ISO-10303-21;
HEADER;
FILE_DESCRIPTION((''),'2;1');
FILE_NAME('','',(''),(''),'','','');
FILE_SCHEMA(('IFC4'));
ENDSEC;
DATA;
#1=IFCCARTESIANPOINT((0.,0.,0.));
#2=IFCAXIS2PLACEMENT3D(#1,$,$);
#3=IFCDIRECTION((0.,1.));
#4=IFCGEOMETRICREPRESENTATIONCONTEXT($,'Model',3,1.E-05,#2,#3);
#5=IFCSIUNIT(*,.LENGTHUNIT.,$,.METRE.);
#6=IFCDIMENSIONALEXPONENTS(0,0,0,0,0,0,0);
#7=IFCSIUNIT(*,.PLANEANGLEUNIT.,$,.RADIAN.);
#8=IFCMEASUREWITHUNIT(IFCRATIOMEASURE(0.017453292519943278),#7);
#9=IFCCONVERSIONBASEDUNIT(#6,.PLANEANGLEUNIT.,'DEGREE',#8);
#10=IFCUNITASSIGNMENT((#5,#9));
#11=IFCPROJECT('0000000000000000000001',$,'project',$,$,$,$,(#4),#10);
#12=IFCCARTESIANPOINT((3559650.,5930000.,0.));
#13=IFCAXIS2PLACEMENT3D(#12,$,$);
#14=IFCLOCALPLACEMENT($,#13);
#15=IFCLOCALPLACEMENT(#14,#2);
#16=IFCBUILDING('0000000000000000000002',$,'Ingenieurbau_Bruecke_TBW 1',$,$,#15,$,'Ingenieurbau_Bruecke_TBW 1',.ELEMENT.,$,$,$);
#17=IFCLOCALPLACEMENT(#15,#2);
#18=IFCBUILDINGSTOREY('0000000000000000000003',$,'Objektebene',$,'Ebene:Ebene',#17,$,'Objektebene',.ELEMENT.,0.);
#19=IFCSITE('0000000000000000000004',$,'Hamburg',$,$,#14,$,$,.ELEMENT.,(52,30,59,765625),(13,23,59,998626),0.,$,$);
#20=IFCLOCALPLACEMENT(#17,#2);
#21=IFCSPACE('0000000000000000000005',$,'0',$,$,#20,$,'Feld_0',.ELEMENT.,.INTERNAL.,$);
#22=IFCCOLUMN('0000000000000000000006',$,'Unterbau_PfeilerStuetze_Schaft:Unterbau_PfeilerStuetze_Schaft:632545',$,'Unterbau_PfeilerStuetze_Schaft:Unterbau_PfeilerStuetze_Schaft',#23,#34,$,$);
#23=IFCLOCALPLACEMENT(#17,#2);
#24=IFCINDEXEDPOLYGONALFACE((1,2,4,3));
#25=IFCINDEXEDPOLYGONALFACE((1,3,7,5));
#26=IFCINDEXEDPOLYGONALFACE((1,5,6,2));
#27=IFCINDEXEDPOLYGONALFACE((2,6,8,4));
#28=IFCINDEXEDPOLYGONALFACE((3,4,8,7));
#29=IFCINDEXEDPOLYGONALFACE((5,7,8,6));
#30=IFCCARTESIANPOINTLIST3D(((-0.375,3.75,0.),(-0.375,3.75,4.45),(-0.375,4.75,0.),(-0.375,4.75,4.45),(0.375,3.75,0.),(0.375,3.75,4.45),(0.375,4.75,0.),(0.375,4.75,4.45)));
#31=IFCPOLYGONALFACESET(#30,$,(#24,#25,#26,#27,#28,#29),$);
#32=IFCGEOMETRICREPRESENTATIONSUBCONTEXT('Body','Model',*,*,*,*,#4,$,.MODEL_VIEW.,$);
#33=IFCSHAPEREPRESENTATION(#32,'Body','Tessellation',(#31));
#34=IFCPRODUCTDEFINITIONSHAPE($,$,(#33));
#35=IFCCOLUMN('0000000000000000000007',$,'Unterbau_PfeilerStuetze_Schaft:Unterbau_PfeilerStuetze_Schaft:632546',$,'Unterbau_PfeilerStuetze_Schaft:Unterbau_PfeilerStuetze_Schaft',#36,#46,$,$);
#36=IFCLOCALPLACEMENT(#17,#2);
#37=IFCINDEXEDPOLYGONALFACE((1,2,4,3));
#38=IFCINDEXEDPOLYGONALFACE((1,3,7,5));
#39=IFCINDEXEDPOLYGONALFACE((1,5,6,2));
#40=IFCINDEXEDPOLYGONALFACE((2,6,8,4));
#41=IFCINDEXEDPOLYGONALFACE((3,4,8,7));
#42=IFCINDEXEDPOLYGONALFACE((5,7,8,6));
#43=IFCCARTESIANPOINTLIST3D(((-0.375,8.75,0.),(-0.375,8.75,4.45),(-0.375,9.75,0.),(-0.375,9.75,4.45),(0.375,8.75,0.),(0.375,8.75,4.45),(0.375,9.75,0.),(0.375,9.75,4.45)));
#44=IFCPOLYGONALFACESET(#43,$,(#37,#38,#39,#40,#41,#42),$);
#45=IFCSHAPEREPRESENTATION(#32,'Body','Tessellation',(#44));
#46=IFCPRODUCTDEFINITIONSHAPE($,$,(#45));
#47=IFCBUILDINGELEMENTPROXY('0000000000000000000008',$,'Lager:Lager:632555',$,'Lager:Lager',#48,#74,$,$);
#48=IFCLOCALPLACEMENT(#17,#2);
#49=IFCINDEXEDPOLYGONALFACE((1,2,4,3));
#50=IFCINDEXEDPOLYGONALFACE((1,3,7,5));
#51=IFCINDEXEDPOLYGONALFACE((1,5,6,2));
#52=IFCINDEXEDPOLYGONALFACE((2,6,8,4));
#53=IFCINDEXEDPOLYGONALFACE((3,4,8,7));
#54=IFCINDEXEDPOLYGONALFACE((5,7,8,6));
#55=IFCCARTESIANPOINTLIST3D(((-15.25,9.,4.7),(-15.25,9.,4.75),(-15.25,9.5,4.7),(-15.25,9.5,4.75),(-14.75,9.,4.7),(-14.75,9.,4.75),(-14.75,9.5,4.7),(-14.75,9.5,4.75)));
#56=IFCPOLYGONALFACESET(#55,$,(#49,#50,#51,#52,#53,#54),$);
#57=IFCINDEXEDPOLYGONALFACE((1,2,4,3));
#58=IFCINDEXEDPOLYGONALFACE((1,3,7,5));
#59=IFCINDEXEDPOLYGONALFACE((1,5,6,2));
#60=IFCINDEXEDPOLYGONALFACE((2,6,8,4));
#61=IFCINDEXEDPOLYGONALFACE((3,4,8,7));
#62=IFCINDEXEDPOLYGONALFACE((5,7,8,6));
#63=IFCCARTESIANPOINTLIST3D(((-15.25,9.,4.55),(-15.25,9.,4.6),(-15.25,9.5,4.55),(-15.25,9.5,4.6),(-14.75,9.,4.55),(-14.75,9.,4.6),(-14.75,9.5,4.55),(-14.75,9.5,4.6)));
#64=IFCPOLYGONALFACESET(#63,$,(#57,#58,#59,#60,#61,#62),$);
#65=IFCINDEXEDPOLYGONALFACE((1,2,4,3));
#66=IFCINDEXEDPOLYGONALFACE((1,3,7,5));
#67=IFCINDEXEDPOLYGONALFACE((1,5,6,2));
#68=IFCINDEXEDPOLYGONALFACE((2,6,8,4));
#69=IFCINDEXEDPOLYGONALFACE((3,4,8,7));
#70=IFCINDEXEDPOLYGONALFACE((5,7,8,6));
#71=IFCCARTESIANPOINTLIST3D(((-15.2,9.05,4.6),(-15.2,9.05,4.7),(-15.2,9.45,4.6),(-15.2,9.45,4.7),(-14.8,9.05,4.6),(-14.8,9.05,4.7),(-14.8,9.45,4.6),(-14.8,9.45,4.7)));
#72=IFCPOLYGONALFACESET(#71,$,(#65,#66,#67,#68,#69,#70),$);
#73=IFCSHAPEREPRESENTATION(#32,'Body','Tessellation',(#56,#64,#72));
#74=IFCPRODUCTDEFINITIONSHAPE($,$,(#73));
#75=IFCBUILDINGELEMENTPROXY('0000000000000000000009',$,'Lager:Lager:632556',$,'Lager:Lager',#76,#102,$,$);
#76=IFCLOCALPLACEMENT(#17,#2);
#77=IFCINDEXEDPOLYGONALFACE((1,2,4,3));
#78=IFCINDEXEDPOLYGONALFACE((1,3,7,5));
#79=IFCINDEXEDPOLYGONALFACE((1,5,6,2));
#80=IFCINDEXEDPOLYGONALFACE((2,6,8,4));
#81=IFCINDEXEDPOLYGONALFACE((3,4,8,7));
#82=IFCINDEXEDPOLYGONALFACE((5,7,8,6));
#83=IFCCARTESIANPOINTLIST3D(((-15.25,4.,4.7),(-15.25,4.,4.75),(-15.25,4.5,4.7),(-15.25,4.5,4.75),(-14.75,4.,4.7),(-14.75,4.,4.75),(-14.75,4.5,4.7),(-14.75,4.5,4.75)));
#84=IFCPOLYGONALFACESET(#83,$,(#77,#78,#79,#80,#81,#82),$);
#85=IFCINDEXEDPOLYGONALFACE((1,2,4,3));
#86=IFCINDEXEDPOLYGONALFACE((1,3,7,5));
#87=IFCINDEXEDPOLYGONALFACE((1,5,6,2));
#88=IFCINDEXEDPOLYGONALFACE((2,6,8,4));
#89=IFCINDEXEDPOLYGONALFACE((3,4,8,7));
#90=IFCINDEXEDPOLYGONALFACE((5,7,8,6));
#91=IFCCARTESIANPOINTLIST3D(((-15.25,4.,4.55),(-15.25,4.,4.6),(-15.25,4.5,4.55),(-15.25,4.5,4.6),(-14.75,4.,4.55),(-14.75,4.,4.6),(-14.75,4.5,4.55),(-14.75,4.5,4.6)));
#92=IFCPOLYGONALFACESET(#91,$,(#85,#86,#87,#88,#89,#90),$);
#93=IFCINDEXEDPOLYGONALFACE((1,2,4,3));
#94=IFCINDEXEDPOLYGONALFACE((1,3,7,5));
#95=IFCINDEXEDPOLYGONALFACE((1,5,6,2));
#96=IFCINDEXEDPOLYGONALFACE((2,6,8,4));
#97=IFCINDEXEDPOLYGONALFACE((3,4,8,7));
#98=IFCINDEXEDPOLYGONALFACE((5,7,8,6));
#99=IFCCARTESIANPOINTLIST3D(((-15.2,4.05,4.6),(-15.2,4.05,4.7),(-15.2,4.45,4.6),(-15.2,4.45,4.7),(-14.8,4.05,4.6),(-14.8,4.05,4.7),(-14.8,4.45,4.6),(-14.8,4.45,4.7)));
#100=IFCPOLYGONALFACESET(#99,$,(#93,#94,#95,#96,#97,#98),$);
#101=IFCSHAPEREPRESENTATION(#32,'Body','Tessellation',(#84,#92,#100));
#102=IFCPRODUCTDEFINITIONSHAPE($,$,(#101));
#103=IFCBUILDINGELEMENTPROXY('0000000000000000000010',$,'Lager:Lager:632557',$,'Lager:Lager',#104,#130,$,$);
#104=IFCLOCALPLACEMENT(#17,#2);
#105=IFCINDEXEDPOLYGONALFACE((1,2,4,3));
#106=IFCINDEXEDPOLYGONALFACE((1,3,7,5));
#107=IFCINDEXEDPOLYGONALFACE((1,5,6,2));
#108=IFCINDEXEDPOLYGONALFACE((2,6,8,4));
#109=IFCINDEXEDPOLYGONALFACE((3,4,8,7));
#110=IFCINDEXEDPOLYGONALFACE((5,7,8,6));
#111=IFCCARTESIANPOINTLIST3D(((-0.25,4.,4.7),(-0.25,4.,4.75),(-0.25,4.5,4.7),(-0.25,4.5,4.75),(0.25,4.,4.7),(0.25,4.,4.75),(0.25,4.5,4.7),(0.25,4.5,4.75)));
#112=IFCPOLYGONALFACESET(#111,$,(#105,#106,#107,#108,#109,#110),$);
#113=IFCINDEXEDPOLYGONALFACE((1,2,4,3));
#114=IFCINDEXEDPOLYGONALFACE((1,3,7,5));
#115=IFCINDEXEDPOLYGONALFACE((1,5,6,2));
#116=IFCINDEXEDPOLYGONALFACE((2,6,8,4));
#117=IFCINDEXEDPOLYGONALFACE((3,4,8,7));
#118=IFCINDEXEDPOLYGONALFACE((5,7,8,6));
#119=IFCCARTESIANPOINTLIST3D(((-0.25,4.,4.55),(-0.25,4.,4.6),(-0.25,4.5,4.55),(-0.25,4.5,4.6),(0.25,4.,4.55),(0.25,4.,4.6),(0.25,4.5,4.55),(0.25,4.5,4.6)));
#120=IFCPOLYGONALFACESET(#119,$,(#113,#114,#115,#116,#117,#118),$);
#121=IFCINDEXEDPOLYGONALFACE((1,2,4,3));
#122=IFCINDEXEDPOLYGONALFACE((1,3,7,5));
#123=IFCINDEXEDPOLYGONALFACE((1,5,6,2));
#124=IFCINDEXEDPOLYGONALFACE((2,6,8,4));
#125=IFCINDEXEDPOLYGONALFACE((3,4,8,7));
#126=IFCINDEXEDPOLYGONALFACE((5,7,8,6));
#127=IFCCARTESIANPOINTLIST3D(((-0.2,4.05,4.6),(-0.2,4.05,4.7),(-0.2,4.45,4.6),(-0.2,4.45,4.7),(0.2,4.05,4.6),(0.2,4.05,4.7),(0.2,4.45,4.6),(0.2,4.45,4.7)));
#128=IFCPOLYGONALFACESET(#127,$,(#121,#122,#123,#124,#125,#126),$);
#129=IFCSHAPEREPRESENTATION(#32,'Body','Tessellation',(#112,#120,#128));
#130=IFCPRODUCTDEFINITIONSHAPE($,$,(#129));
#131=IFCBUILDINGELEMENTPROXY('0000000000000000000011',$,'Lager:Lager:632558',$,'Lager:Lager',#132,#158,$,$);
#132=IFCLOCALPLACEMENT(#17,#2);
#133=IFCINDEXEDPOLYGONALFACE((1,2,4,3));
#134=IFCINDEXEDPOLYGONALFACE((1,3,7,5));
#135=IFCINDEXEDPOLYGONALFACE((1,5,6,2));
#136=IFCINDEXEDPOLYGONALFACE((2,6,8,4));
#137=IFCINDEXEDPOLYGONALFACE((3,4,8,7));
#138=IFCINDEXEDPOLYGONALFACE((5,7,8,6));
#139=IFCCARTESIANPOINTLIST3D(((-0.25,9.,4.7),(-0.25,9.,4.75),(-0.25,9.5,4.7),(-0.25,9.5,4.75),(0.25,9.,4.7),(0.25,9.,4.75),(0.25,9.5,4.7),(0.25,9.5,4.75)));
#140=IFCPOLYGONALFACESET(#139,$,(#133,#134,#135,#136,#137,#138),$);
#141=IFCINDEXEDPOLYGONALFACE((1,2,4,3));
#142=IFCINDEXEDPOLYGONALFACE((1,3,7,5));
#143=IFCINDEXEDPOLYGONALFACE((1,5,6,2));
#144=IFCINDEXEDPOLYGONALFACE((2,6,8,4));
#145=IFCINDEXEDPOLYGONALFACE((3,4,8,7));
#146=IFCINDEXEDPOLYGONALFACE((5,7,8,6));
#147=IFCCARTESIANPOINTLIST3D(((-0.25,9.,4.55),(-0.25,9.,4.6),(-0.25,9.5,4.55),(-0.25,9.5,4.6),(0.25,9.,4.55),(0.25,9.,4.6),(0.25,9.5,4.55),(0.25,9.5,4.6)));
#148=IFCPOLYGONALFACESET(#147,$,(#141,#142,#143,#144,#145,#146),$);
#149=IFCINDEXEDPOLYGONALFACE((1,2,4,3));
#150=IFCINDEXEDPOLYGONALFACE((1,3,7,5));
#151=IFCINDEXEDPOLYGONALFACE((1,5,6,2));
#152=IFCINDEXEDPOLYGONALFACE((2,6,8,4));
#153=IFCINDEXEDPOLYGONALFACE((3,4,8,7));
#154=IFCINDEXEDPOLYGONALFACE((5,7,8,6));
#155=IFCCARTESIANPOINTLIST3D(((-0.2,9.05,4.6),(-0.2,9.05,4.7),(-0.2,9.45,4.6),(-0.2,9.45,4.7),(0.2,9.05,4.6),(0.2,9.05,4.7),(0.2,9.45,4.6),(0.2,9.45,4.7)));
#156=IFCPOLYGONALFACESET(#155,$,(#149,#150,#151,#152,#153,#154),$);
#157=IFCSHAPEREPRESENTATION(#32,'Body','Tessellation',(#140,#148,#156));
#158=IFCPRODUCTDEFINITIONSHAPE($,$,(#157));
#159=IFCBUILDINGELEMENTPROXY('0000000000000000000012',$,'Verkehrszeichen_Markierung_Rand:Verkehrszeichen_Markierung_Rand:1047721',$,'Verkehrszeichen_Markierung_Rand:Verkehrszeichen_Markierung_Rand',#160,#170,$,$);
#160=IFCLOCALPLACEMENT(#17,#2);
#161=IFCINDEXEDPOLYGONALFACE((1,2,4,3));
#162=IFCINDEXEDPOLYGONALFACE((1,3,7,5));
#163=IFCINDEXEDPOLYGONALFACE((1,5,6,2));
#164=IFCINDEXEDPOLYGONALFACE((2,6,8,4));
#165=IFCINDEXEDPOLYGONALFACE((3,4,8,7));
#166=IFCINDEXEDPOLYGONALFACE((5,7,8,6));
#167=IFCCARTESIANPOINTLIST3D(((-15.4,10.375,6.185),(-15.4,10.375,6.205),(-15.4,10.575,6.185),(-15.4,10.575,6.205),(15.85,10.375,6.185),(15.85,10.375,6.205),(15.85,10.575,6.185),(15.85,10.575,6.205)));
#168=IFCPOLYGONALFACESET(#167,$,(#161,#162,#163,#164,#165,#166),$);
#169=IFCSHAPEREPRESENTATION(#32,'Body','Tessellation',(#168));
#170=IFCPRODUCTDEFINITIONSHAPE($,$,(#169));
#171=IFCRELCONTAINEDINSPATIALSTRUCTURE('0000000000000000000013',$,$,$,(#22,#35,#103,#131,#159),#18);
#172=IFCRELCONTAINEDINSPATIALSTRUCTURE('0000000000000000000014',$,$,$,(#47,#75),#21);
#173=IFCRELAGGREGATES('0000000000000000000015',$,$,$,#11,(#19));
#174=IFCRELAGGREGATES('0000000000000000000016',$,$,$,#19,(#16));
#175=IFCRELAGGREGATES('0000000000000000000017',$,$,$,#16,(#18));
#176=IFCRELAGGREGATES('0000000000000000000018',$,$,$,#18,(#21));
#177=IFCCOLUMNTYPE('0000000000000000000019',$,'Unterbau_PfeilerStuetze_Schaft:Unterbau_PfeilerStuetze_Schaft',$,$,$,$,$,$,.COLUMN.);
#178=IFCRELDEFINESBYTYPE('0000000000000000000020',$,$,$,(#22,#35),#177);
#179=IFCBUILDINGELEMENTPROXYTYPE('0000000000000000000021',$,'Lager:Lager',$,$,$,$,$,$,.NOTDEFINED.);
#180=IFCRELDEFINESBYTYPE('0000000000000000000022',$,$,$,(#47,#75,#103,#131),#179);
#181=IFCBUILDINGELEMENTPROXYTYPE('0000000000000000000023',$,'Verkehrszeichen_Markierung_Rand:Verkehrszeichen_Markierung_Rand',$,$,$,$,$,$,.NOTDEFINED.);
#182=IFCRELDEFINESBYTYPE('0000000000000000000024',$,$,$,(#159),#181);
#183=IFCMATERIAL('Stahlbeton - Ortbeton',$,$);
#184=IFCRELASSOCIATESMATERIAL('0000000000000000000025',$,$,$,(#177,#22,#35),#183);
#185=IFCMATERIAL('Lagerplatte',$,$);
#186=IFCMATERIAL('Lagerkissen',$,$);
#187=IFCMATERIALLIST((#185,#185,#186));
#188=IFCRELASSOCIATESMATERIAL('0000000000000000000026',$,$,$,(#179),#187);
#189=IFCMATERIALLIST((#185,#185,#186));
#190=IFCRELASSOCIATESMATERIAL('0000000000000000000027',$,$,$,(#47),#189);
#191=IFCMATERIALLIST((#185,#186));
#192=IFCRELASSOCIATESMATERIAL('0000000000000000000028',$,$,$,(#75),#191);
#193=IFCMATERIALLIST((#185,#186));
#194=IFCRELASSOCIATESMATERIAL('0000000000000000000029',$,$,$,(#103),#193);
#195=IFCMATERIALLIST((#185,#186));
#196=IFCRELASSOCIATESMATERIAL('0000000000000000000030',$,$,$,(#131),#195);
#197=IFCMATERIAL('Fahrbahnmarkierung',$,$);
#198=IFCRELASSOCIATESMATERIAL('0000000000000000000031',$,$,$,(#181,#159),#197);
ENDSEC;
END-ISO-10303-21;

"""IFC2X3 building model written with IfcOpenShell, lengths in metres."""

from ifc_helpers import new_model, entity, si_unit, converted_unit, direction, frame, frame_2d, origin, origin_2d_with_axis, place, context, subcontext, project, spatial, rectangle, extrude, source, transform, mapped, material, material_list, type_object, type_shapes, element, save


model = new_model("IFC2X3")

# Units and contexts
model_context = context("Model", 3, precision=1e-05, world=origin(), true_north=direction((0.0, 1.0)))
body_context = subcontext(model_context, "Body", "Model", "MODEL_VIEW")
ifc_project = project(units=[si_unit("LENGTHUNIT", "METRE"), converted_unit("PLANEANGLEUNIT", "DEGREE", entity("IfcRatioMeasure", 0.017453292519943278), si_unit("PLANEANGLEUNIT", "RADIAN"), dimensions=[0, 0, 0, 0, 0, 0, 0])], contexts=[model_context])

# Site, building, storey
site_placement = place(None, frame((3559650.0, 5930000.0, 0.0)))
site = spatial("IfcSite", under=ifc_project, at=site_placement, Name="Hamburg", CompositionType="ELEMENT", RefLatitude=(52, 30, 59, 765625), RefLongitude=(13, 23, 59, 998626), RefElevation=0.0)
building_placement = place(site_placement, origin())
building = spatial("IfcBuilding", under=site, at=building_placement, Name="Ingenieurbau_Bruecke_TBW 1", LongName="Ingenieurbau_Bruecke_TBW 1", CompositionType="ELEMENT")
storey_placement = place(building_placement, origin())
storey = spatial("IfcBuildingStorey", under=building, at=storey_placement, Name="Objektebene", ObjectType="Ebene:Ebene", LongName="Objektebene", CompositionType="ELEMENT", Elevation=0.0)

# Columns
ifc_material_1 = material(Name="Stahlbeton - Ortbeton")
column_type = type_object("IfcColumnType", Name="Unterbau_PfeilerStuetze_Schaft:Unterbau_PfeilerStuetze_Schaft", PredefinedType="COLUMN", material=ifc_material_1)
shared_shape_1 = source(origin(), body_context, "Body", "SweptSolid", [
    extrude(rectangle(XDim=1.0, YDim=0.75, at=frame_2d((0.0, 0.0), x_axis=(1.0, 0.0))), frame((0.0, 0.0, 0.0), z_axis=(0.0, 0.0, 1.0), x_axis=(0.0, -1.0, 0.0)), (0.0, 0.0, 1.0), 4.45),
])
type_shapes(column_type, [shared_shape_1])
for number, where, name in (
    (1, (0.0, 4.25, 0.0), "Unterbau_PfeilerStuetze_Schaft:Unterbau_PfeilerStuetze_Schaft:632545"),
    (2, (0.0, 9.25, 0.0), "Unterbau_PfeilerStuetze_Schaft:Unterbau_PfeilerStuetze_Schaft:632546"),
):
    element("IfcColumn", number, at=place(storey_placement, frame(where)), inside=storey, type_object=column_type, material=ifc_material_1, Name=name, ObjectType="Unterbau_PfeilerStuetze_Schaft:Unterbau_PfeilerStuetze_Schaft", context=body_context, shape_type="MappedRepresentation", body=[
        mapped(shared_shape_1, transform((0.0, 0.0, 0.0), scale=1.0)),
    ])

# Shared definitions
space_placement = place(storey_placement, origin())
space = spatial("IfcSpace", under=storey, at=space_placement, Name="0", LongName="Feld_0", CompositionType="ELEMENT", InteriorOrExteriorSpace="INTERNAL")

# Building element proxies
ifc_material_2 = material(Name="Lagerplatte")
ifc_material_3 = material(Name="Lagerkissen")
ifc_material_list_1 = material_list([ifc_material_2, ifc_material_2, ifc_material_3])
ifc_material_list_2 = material_list([ifc_material_2, ifc_material_2, ifc_material_3])
building_element_proxy_type_1 = type_object("IfcBuildingElementProxyType", Name="Lager:Lager", PredefinedType="NOTDEFINED", material=ifc_material_list_2)
shared_shape_2 = source(origin(), body_context, "Body", "SweptSolid", [
    extrude(rectangle(XDim=0.5, YDim=0.5, at=origin_2d_with_axis()), frame((0.0, 0.0, 4.7), z_axis=(0.0, 0.0, 1.0), x_axis=(0.0, 1.0, 0.0)), (0.0, 0.0, 1.0), 0.05),
    extrude(rectangle(XDim=0.5, YDim=0.5, at=origin_2d_with_axis()), frame((0.0, 0.0, 4.55), z_axis=(0.0, 0.0, 1.0), x_axis=(0.0, 1.0, 0.0)), (0.0, 0.0, 1.0), 0.05),
    extrude(rectangle(XDim=0.4, YDim=0.4, at=origin_2d_with_axis()), frame((0.0, 0.0, 4.6), z_axis=(0.0, 0.0, 1.0), x_axis=(0.0, 1.0, 0.0)), (0.0, 0.0, 1.0), 0.1),
])
type_shapes(building_element_proxy_type_1, [shared_shape_2])
proxy_1_placement = place(space_placement, frame((-15.0, 9.25, 0.0)))
element("IfcBuildingElementProxy", 3, at=proxy_1_placement, inside=space, type_object=building_element_proxy_type_1, material=ifc_material_list_1, Name="Lager:Lager:632555", ObjectType="Lager:Lager", context=body_context, shape_type="MappedRepresentation", body=[
    mapped(shared_shape_2, transform((0.0, 0.0, 0.0), scale=1.0)),
])
ifc_material_list_3 = material_list([ifc_material_2, ifc_material_3])
proxy_2_placement = place(space_placement, frame((-15.0, 4.25, 0.0)))
element("IfcBuildingElementProxy", 4, at=proxy_2_placement, inside=space, type_object=building_element_proxy_type_1, material=ifc_material_list_3, Name="Lager:Lager:632556", ObjectType="Lager:Lager", context=body_context, shape_type="MappedRepresentation", body=[
    mapped(shared_shape_2, transform((0.0, 0.0, 0.0), scale=1.0)),
])
ifc_material_list_4 = material_list([ifc_material_2, ifc_material_3])
proxy_3_placement = place(storey_placement, frame((0.0, 4.25, 0.0)))
element("IfcBuildingElementProxy", 5, at=proxy_3_placement, inside=storey, type_object=building_element_proxy_type_1, material=ifc_material_list_4, Name="Lager:Lager:632557", ObjectType="Lager:Lager", context=body_context, shape_type="MappedRepresentation", body=[
    mapped(shared_shape_2, transform((0.0, 0.0, 0.0), scale=1.0)),
])
ifc_material_list_5 = material_list([ifc_material_2, ifc_material_3])
proxy_4_placement = place(storey_placement, frame((0.0, 9.25, 0.0)))
element("IfcBuildingElementProxy", 6, at=proxy_4_placement, inside=storey, type_object=building_element_proxy_type_1, material=ifc_material_list_5, Name="Lager:Lager:632558", ObjectType="Lager:Lager", context=body_context, shape_type="MappedRepresentation", body=[
    mapped(shared_shape_2, transform((0.0, 0.0, 0.0), scale=1.0)),
])
ifc_material_4 = material(Name="Fahrbahnmarkierung")
building_element_proxy_type_2 = type_object("IfcBuildingElementProxyType", Name="Verkehrszeichen_Markierung_Rand:Verkehrszeichen_Markierung_Rand", PredefinedType="NOTDEFINED", material=ifc_material_4)
shared_shape_3 = source(origin(), body_context, "Body", "SweptSolid", [
    extrude(rectangle(XDim=31.25, YDim=0.2, at=origin_2d_with_axis()), frame((15.625, -5.335, 6.185), z_axis=(0.0, 0.0, 1.0), x_axis=(-1.0, 0.0, 0.0)), (0.0, 0.0, 1.0), 0.02),
])
type_shapes(building_element_proxy_type_2, [shared_shape_3])
proxy_5_placement = place(storey_placement, frame((-15.4, 15.81, 0.0)))
element("IfcBuildingElementProxy", 7, at=proxy_5_placement, inside=storey, type_object=building_element_proxy_type_2, material=ifc_material_4, Name="Verkehrszeichen_Markierung_Rand:Verkehrszeichen_Markierung_Rand:1047721", ObjectType="Verkehrszeichen_Markierung_Rand:Verkehrszeichen_Markierung_Rand", context=body_context, shape_type="MappedRepresentation", body=[
    mapped(shared_shape_3, transform((0.0, 0.0, 0.0), scale=1.0)),
])

save(model, "model.ifc")
